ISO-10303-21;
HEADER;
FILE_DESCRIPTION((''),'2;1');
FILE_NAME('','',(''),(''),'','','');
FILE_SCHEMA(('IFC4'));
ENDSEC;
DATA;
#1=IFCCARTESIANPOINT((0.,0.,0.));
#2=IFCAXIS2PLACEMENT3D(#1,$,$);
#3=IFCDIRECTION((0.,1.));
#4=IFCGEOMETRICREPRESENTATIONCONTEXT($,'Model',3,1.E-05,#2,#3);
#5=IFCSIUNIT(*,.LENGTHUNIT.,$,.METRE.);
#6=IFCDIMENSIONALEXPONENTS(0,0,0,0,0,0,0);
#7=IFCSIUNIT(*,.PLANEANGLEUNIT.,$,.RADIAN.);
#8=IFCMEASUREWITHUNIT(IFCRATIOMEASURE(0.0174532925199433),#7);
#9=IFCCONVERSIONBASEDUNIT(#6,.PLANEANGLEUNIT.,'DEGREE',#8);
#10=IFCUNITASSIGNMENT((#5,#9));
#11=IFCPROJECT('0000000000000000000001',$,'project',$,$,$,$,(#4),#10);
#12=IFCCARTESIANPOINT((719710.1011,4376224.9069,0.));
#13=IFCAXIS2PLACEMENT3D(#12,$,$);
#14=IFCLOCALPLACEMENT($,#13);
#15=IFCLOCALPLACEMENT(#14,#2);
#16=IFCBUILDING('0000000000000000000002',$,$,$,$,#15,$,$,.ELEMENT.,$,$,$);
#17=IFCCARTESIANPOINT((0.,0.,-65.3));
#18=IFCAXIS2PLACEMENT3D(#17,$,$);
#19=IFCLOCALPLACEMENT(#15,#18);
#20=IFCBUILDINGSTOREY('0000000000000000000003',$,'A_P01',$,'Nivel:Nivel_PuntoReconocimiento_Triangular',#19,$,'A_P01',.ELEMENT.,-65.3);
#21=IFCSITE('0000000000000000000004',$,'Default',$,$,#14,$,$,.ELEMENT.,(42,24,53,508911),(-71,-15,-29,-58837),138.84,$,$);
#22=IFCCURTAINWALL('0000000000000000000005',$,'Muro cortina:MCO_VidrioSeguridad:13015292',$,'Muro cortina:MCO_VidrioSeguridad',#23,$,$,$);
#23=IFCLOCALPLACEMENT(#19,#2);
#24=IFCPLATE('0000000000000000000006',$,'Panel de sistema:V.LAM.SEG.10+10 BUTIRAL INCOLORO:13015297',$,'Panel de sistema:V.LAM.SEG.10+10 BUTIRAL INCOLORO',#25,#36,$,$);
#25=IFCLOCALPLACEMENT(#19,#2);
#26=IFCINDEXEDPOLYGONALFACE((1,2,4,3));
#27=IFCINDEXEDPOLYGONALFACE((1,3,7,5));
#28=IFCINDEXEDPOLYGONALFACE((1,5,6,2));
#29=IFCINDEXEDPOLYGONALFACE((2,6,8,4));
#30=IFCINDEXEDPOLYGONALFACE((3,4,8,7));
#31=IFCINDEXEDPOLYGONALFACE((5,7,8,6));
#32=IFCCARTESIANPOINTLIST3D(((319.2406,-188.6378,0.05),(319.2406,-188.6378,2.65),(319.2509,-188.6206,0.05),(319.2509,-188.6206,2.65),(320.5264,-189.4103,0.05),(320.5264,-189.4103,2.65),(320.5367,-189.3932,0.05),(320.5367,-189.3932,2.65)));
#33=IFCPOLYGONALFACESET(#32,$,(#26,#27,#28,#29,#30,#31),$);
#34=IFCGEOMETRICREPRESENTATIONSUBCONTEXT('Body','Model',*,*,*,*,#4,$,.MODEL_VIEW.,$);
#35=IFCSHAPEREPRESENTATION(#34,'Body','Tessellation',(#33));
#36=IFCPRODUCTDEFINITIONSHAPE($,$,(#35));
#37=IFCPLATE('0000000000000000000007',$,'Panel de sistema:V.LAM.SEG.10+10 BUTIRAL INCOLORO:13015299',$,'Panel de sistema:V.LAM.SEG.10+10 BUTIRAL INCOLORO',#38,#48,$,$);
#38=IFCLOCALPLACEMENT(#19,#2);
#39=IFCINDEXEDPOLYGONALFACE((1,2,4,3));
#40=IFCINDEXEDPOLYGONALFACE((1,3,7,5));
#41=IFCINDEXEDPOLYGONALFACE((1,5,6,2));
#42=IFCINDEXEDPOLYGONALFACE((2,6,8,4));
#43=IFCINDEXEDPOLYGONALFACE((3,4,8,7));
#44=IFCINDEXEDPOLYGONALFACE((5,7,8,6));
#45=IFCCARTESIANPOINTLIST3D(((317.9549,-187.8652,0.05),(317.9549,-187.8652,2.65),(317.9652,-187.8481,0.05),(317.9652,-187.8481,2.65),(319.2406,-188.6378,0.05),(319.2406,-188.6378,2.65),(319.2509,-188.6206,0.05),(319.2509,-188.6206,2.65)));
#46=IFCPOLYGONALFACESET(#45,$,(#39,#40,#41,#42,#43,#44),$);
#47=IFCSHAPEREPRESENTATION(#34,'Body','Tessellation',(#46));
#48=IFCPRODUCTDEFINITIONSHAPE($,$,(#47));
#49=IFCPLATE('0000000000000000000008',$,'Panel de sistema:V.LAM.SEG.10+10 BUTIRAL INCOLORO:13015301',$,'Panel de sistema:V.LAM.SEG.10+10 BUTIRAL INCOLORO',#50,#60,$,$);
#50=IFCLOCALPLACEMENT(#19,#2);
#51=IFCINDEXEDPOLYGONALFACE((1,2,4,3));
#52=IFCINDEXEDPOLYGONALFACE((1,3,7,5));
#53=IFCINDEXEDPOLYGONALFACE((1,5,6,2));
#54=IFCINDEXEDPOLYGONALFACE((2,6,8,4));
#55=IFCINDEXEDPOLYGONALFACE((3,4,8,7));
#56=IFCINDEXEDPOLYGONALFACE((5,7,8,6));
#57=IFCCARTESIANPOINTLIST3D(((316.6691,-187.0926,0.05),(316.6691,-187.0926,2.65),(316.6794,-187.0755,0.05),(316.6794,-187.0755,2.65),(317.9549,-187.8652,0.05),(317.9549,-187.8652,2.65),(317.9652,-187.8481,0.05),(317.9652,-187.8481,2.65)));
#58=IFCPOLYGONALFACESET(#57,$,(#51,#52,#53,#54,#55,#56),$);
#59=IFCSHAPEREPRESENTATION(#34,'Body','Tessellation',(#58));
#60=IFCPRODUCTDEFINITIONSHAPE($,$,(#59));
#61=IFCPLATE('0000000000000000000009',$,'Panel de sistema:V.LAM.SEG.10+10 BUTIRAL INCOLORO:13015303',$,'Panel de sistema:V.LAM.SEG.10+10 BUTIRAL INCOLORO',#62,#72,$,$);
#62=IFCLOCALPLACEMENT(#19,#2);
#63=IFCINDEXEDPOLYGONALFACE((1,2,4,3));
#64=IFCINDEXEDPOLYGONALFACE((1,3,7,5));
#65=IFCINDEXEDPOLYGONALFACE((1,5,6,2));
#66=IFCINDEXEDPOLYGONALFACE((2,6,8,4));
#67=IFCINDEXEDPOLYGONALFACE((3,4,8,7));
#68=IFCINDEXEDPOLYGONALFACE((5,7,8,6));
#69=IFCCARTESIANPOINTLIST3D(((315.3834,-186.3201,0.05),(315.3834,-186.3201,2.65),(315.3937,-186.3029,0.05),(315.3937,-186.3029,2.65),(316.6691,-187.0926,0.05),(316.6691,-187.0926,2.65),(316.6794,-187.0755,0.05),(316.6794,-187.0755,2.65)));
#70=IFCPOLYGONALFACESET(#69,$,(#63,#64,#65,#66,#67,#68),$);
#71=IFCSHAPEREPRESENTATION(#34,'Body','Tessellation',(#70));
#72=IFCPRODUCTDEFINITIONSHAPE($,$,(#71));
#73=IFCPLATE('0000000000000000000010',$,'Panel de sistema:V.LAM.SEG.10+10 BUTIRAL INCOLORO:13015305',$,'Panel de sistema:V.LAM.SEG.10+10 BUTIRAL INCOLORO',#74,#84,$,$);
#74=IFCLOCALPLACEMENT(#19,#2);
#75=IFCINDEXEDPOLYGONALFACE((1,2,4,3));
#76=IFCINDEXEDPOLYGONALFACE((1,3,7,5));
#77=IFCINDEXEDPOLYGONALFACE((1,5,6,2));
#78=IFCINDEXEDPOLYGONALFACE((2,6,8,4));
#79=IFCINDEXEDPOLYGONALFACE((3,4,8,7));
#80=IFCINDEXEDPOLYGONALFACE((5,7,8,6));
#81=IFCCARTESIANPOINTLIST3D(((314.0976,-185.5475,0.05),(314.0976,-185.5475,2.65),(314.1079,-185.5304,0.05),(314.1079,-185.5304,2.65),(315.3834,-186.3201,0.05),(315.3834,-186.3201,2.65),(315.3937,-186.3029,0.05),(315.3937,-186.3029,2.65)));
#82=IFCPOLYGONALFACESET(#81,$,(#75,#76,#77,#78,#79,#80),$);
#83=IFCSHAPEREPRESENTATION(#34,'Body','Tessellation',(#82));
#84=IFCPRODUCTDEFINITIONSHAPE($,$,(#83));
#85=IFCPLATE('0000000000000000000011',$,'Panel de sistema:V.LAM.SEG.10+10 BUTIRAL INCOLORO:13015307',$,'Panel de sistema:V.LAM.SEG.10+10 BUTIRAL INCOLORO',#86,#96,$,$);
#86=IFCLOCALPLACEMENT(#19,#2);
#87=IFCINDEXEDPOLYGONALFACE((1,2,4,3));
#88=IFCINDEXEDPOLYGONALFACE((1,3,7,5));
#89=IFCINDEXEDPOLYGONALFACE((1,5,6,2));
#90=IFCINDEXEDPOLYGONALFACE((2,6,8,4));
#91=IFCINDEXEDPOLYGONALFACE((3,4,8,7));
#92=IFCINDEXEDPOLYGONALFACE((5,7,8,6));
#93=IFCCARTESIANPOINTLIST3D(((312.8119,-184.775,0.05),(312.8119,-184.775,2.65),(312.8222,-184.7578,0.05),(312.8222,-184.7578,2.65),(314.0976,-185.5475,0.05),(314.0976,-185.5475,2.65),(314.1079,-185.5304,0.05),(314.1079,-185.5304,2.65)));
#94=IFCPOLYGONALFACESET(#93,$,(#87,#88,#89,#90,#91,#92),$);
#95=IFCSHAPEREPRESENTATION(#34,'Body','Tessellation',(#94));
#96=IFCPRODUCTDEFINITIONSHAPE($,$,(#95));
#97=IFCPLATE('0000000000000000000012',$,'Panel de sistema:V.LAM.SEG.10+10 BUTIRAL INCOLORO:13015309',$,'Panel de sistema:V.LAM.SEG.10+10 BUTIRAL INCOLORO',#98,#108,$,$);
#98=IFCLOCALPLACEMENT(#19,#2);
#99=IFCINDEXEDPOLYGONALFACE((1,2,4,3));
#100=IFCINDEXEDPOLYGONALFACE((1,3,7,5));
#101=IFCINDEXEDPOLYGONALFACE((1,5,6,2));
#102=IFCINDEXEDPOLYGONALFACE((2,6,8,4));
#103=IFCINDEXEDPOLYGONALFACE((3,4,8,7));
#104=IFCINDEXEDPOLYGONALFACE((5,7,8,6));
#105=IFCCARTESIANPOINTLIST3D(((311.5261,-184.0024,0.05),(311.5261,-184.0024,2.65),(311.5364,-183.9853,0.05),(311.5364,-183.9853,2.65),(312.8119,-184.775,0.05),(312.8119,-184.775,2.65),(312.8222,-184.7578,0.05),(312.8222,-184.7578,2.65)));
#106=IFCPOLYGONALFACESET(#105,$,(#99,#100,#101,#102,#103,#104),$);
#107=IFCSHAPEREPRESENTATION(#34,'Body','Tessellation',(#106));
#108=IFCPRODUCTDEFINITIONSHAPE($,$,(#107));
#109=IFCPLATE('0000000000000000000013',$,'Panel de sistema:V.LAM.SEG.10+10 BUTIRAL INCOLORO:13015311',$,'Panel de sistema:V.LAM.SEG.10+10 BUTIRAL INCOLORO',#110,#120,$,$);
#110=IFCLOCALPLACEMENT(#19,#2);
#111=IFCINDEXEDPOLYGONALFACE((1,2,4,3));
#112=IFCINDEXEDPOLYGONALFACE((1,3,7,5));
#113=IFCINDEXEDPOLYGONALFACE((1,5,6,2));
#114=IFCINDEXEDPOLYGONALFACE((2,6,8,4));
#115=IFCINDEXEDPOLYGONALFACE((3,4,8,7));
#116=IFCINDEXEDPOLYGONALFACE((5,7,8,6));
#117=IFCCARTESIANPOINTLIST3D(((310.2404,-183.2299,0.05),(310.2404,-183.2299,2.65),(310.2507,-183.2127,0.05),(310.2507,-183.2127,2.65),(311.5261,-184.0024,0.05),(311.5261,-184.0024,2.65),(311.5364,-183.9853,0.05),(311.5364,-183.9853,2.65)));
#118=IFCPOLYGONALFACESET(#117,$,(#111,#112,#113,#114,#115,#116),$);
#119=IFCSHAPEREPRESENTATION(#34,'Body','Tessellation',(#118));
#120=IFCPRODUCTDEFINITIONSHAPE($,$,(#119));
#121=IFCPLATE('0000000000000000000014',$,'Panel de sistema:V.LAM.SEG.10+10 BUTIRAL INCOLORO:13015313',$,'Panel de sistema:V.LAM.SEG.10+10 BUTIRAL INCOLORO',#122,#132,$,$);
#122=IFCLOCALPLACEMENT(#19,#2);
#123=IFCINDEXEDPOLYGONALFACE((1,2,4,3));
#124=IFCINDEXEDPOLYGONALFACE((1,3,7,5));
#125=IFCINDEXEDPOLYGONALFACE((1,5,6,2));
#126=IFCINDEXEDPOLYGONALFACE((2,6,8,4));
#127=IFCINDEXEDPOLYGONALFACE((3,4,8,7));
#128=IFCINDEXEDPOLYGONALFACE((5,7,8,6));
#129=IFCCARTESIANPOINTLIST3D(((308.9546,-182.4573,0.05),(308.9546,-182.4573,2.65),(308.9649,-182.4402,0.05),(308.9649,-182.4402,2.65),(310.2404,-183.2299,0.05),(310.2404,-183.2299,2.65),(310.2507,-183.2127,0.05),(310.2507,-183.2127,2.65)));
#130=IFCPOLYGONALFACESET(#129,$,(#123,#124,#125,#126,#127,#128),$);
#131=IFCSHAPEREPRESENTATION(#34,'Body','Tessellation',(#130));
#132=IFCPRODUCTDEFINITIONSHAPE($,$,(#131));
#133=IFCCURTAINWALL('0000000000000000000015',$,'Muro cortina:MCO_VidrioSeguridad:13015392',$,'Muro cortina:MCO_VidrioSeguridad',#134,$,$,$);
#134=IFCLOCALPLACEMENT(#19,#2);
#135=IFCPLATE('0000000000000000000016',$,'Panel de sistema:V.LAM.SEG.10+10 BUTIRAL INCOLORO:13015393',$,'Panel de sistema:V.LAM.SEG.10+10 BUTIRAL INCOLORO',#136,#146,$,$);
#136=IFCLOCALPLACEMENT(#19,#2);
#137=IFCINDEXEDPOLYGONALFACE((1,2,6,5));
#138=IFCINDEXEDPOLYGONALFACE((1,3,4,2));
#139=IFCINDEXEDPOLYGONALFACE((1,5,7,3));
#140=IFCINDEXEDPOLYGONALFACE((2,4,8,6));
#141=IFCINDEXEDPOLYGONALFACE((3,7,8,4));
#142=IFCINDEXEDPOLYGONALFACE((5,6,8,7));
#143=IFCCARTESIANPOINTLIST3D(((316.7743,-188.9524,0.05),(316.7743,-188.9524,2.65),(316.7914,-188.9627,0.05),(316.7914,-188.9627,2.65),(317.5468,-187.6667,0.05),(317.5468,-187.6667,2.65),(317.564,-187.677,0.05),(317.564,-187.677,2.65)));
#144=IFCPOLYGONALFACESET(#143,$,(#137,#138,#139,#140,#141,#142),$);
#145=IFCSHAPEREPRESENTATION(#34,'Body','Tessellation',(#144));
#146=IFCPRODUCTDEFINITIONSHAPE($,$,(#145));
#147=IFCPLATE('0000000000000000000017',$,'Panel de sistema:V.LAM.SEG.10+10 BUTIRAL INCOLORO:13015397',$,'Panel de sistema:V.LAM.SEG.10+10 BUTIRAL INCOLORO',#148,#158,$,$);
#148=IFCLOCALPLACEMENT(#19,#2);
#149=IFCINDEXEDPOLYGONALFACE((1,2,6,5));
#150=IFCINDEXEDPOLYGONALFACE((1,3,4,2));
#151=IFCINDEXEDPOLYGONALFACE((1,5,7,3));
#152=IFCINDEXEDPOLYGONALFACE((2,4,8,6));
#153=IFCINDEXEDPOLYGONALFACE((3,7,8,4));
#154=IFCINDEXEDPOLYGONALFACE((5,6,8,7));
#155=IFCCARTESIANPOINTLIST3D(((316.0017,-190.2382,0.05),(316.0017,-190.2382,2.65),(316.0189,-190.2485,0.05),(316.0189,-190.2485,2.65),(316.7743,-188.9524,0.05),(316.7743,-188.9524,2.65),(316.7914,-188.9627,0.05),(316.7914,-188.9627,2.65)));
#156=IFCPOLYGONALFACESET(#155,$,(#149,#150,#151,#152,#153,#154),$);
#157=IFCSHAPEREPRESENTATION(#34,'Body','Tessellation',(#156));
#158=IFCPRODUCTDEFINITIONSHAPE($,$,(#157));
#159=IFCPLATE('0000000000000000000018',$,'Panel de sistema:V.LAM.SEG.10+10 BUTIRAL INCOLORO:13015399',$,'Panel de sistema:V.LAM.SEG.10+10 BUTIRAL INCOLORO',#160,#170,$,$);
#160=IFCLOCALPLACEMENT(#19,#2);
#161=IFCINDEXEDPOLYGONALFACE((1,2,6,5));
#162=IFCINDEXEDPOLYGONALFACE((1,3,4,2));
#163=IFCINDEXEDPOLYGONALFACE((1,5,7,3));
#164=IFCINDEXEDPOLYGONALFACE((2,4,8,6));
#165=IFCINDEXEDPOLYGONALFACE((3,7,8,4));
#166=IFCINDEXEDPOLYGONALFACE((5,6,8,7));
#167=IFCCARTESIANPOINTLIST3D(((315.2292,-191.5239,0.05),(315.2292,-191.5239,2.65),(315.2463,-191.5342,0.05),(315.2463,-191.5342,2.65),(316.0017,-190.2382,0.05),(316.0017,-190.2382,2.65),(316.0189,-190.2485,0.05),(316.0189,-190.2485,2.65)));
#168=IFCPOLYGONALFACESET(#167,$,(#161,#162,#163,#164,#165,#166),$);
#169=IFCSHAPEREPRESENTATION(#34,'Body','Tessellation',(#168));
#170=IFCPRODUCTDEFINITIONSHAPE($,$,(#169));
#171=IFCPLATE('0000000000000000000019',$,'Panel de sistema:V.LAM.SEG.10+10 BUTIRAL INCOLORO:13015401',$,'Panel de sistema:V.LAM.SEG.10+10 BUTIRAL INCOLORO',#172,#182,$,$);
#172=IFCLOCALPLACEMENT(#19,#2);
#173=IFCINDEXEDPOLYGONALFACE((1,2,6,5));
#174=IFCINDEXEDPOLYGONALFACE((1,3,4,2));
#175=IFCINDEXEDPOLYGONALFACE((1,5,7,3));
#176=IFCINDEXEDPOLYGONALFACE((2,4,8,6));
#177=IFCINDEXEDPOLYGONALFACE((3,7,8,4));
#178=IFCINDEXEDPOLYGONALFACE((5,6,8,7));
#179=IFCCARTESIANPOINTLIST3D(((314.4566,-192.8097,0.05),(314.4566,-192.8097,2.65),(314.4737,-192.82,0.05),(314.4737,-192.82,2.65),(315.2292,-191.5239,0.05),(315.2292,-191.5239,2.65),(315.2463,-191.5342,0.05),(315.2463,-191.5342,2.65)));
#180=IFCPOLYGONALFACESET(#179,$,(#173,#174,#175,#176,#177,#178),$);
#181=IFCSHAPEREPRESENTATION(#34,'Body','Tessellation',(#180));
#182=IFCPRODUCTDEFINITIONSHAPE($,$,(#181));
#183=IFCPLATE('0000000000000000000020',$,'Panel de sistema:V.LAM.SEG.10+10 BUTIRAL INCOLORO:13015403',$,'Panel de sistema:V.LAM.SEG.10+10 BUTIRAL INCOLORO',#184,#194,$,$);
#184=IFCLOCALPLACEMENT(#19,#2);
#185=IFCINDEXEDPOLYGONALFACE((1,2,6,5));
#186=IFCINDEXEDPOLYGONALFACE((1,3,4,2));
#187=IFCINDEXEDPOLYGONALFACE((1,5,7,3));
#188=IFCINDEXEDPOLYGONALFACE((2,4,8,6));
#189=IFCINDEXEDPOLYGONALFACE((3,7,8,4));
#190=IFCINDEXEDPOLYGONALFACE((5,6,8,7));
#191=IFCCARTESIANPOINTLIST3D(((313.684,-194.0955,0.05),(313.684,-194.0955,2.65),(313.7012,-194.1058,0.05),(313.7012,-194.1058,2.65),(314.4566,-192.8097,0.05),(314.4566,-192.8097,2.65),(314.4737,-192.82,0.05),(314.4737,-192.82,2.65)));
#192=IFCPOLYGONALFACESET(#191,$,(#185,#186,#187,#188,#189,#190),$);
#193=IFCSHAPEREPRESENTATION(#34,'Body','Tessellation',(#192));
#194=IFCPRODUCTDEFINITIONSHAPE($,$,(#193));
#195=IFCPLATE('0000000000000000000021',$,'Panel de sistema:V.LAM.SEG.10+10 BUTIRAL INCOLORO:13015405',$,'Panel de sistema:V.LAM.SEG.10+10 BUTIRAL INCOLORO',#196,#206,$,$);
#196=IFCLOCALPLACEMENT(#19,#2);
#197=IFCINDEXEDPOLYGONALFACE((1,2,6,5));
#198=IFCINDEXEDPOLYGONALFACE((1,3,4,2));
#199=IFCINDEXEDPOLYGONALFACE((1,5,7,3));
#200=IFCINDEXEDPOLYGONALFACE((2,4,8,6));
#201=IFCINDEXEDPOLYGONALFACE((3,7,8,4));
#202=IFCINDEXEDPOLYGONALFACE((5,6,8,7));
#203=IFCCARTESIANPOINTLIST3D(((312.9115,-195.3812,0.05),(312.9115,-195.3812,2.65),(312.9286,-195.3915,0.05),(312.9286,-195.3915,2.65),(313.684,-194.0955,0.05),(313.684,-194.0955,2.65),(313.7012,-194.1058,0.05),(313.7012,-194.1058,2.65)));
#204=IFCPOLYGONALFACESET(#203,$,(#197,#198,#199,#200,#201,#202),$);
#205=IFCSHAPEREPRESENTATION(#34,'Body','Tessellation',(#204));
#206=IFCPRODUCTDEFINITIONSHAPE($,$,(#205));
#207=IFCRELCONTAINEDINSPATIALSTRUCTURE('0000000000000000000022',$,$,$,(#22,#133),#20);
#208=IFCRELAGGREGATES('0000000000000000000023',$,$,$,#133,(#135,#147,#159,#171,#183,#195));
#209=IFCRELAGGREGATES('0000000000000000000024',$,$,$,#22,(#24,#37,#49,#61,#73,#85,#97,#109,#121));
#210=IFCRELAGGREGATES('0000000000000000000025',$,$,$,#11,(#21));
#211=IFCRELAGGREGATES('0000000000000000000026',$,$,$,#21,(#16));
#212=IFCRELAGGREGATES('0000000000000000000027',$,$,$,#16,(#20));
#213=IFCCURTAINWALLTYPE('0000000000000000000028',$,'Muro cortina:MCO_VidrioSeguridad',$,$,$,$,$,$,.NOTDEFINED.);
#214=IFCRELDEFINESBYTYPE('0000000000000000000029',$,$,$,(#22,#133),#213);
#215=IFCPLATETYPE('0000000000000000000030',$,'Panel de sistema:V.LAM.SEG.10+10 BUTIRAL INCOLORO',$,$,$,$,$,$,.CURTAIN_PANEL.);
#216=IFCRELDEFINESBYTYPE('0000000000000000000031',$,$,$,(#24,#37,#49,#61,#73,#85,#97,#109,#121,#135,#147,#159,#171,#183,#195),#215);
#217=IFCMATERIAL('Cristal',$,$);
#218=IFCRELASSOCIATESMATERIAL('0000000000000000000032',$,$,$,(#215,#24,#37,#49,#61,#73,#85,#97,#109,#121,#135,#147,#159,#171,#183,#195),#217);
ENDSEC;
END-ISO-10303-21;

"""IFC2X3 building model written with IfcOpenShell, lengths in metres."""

from ifc_helpers import new_model, entity, si_unit, converted_unit, direction, frame, origin, origin_2d_with_axis, place, context, subcontext, project, spatial, rectangle, extrude, source, transform, mapped, material, type_object, type_shapes, element, aggregate, save


model = new_model("IFC2X3")

# Units and contexts
model_context = context("Model", 3, precision=1e-05, world=origin(), true_north=direction((0.0, 1.0)))
body_context = subcontext(model_context, "Body", "Model", "MODEL_VIEW")
ifc_project = project(units=[si_unit("LENGTHUNIT", "METRE"), converted_unit("PLANEANGLEUNIT", "DEGREE", entity("IfcRatioMeasure", 0.0174532925199433), si_unit("PLANEANGLEUNIT", "RADIAN"), dimensions=[0, 0, 0, 0, 0, 0, 0])], contexts=[model_context])

# Site, building, storey
site_placement = place(None, frame((719710.1011, 4376224.9069, 0.0)))
site = spatial("IfcSite", under=ifc_project, at=site_placement, Name="Default", CompositionType="ELEMENT", RefLatitude=(42, 24, 53, 508911), RefLongitude=(-71, -15, -29, -58837), RefElevation=138.84)
building_placement = place(site_placement, origin())
building = spatial("IfcBuilding", under=site, at=building_placement, CompositionType="ELEMENT")
storey_placement = place(building_placement, frame((0.0, 0.0, -65.3)))
storey = spatial("IfcBuildingStorey", under=building, at=storey_placement, Name="A_P01", ObjectType="Nivel:Nivel_PuntoReconocimiento_Triangular", LongName="A_P01", CompositionType="ELEMENT", Elevation=-65.3)

# Curtain walls, plates
curtain_wall_type = type_object("IfcCurtainWallType", Name="Muro cortina:MCO_VidrioSeguridad", PredefinedType="NOTDEFINED")
curtain_wall_1_placement = place(storey_placement, frame((0.0, 0.0, 65.3)))
curtain_wall_1 = element("IfcCurtainWall", 1, at=curtain_wall_1_placement, inside=storey, type_object=curtain_wall_type, Name="Muro cortina:MCO_VidrioSeguridad:13015292", ObjectType="Muro cortina:MCO_VidrioSeguridad")
ifc_material = material(Name="Cristal")
plate_type_1 = type_object("IfcPlateType", Name="Panel de sistema:V.LAM.SEG.10+10 BUTIRAL INCOLORO", PredefinedType="CURTAIN_PANEL", material=ifc_material)
shared_shape_1 = source(origin(), body_context, "Body", "SweptSolid", [
    extrude(rectangle(XDim=0.02, YDim=1.5, at=origin_2d_with_axis()), frame((0.0, 0.0, 0.0), z_axis=(0.0, 0.0, 1.0), x_axis=(0.0, 1.0, 0.0)), (0.0, 0.0, 1.0), 2.6),
])
type_shapes(plate_type_1, [shared_shape_1])
plate_1_placement = place(curtain_wall_1_placement, frame((319.8886, -189.0155, -65.25), z_axis=(0.0, 0.0, 1.0), x_axis=(-0.857167, 0.515038, 0.0)))
plate_1 = element("IfcPlate", 2, at=plate_1_placement, type_object=plate_type_1, material=ifc_material, Name="Panel de sistema:V.LAM.SEG.10+10 BUTIRAL INCOLORO:13015297", ObjectType="Panel de sistema:V.LAM.SEG.10+10 BUTIRAL INCOLORO", context=body_context, shape_type="MappedRepresentation", body=[
    mapped(shared_shape_1, transform((0.0, 0.0, 0.0), scale=1.0)),
])
plate_2_placement = place(curtain_wall_1_placement, frame((318.6029, -188.2429, -65.25), z_axis=(0.0, 0.0, 1.0), x_axis=(-0.857167, 0.515038, 0.0)))
plate_2 = element("IfcPlate", 3, at=plate_2_placement, type_object=plate_type_1, material=ifc_material, Name="Panel de sistema:V.LAM.SEG.10+10 BUTIRAL INCOLORO:13015299", ObjectType="Panel de sistema:V.LAM.SEG.10+10 BUTIRAL INCOLORO", context=body_context, shape_type="MappedRepresentation", body=[
    mapped(shared_shape_1, transform((0.0, 0.0, 0.0), scale=1.0)),
])
plate_3_placement = place(curtain_wall_1_placement, frame((317.3171, -187.4704, -65.25), z_axis=(0.0, 0.0, 1.0), x_axis=(-0.857167, 0.515038, 0.0)))
plate_3 = element("IfcPlate", 4, at=plate_3_placement, type_object=plate_type_1, material=ifc_material, Name="Panel de sistema:V.LAM.SEG.10+10 BUTIRAL INCOLORO:13015301", ObjectType="Panel de sistema:V.LAM.SEG.10+10 BUTIRAL INCOLORO", context=body_context, shape_type="MappedRepresentation", body=[
    mapped(shared_shape_1, transform((0.0, 0.0, 0.0), scale=1.0)),
])
plate_4_placement = place(curtain_wall_1_placement, frame((316.0314, -186.6978, -65.25), z_axis=(0.0, 0.0, 1.0), x_axis=(-0.857167, 0.515038, 0.0)))
plate_4 = element("IfcPlate", 5, at=plate_4_placement, type_object=plate_type_1, material=ifc_material, Name="Panel de sistema:V.LAM.SEG.10+10 BUTIRAL INCOLORO:13015303", ObjectType="Panel de sistema:V.LAM.SEG.10+10 BUTIRAL INCOLORO", context=body_context, shape_type="MappedRepresentation", body=[
    mapped(shared_shape_1, transform((0.0, 0.0, 0.0), scale=1.0)),
])
plate_5_placement = place(curtain_wall_1_placement, frame((314.7456, -185.9252, -65.25), z_axis=(0.0, 0.0, 1.0), x_axis=(-0.857167, 0.515038, 0.0)))
plate_5 = element("IfcPlate", 6, at=plate_5_placement, type_object=plate_type_1, material=ifc_material, Name="Panel de sistema:V.LAM.SEG.10+10 BUTIRAL INCOLORO:13015305", ObjectType="Panel de sistema:V.LAM.SEG.10+10 BUTIRAL INCOLORO", context=body_context, shape_type="MappedRepresentation", body=[
    mapped(shared_shape_1, transform((0.0, 0.0, 0.0), scale=1.0)),
])
plate_6_placement = place(curtain_wall_1_placement, frame((313.4599, -185.1527, -65.25), z_axis=(0.0, 0.0, 1.0), x_axis=(-0.857167, 0.515038, 0.0)))
plate_6 = element("IfcPlate", 7, at=plate_6_placement, type_object=plate_type_1, material=ifc_material, Name="Panel de sistema:V.LAM.SEG.10+10 BUTIRAL INCOLORO:13015307", ObjectType="Panel de sistema:V.LAM.SEG.10+10 BUTIRAL INCOLORO", context=body_context, shape_type="MappedRepresentation", body=[
    mapped(shared_shape_1, transform((0.0, 0.0, 0.0), scale=1.0)),
])
plate_7_placement = place(curtain_wall_1_placement, frame((312.1741, -184.3801, -65.25), z_axis=(0.0, 0.0, 1.0), x_axis=(-0.857167, 0.515038, 0.0)))
plate_7 = element("IfcPlate", 8, at=plate_7_placement, type_object=plate_type_1, material=ifc_material, Name="Panel de sistema:V.LAM.SEG.10+10 BUTIRAL INCOLORO:13015309", ObjectType="Panel de sistema:V.LAM.SEG.10+10 BUTIRAL INCOLORO", context=body_context, shape_type="MappedRepresentation", body=[
    mapped(shared_shape_1, transform((0.0, 0.0, 0.0), scale=1.0)),
])
plate_8_placement = place(curtain_wall_1_placement, frame((310.8884, -183.6076, -65.25), z_axis=(0.0, 0.0, 1.0), x_axis=(-0.857167, 0.515038, 0.0)))
plate_8 = element("IfcPlate", 9, at=plate_8_placement, type_object=plate_type_1, material=ifc_material, Name="Panel de sistema:V.LAM.SEG.10+10 BUTIRAL INCOLORO:13015311", ObjectType="Panel de sistema:V.LAM.SEG.10+10 BUTIRAL INCOLORO", context=body_context, shape_type="MappedRepresentation", body=[
    mapped(shared_shape_1, transform((0.0, 0.0, 0.0), scale=1.0)),
])
plate_9_placement = place(curtain_wall_1_placement, frame((309.6026, -182.835, -65.25), z_axis=(0.0, 0.0, 1.0), x_axis=(-0.857167, 0.515038, 0.0)))
plate_9 = element("IfcPlate", 10, at=plate_9_placement, type_object=plate_type_1, material=ifc_material, Name="Panel de sistema:V.LAM.SEG.10+10 BUTIRAL INCOLORO:13015313", ObjectType="Panel de sistema:V.LAM.SEG.10+10 BUTIRAL INCOLORO", context=body_context, shape_type="MappedRepresentation", body=[
    mapped(shared_shape_1, transform((0.0, 0.0, 0.0), scale=1.0)),
])
curtain_wall_2_placement = place(storey_placement, frame((0.0, 0.0, 65.3)))
curtain_wall_2 = element("IfcCurtainWall", 11, at=curtain_wall_2_placement, inside=storey, type_object=curtain_wall_type, Name="Muro cortina:MCO_VidrioSeguridad:13015392", ObjectType="Muro cortina:MCO_VidrioSeguridad")
plate_10_placement = place(curtain_wall_2_placement, frame((317.1691, -188.3147, -65.25), z_axis=(0.0, 0.0, 1.0), x_axis=(-0.515038, -0.857167, 0.0)))
plate_10 = element("IfcPlate", 12, at=plate_10_placement, type_object=plate_type_1, material=ifc_material, Name="Panel de sistema:V.LAM.SEG.10+10 BUTIRAL INCOLORO:13015393", ObjectType="Panel de sistema:V.LAM.SEG.10+10 BUTIRAL INCOLORO", context=body_context, shape_type="MappedRepresentation", body=[
    mapped(shared_shape_1, transform((0.0, 0.0, 0.0), scale=1.0)),
])
plate_11_placement = place(curtain_wall_2_placement, frame((316.3966, -189.6005, -65.25), z_axis=(0.0, 0.0, 1.0), x_axis=(-0.515038, -0.857167, 0.0)))
plate_11 = element("IfcPlate", 13, at=plate_11_placement, type_object=plate_type_1, material=ifc_material, Name="Panel de sistema:V.LAM.SEG.10+10 BUTIRAL INCOLORO:13015397", ObjectType="Panel de sistema:V.LAM.SEG.10+10 BUTIRAL INCOLORO", context=body_context, shape_type="MappedRepresentation", body=[
    mapped(shared_shape_1, transform((0.0, 0.0, 0.0), scale=1.0)),
])
plate_12_placement = place(curtain_wall_2_placement, frame((315.624, -190.8862, -65.25), z_axis=(0.0, 0.0, 1.0), x_axis=(-0.515038, -0.857167, 0.0)))
plate_12 = element("IfcPlate", 14, at=plate_12_placement, type_object=plate_type_1, material=ifc_material, Name="Panel de sistema:V.LAM.SEG.10+10 BUTIRAL INCOLORO:13015399", ObjectType="Panel de sistema:V.LAM.SEG.10+10 BUTIRAL INCOLORO", context=body_context, shape_type="MappedRepresentation", body=[
    mapped(shared_shape_1, transform((0.0, 0.0, 0.0), scale=1.0)),
])
plate_13_placement = place(curtain_wall_2_placement, frame((314.8514, -192.172, -65.25), z_axis=(0.0, 0.0, 1.0), x_axis=(-0.515038, -0.857167, 0.0)))
plate_13 = element("IfcPlate", 15, at=plate_13_placement, type_object=plate_type_1, material=ifc_material, Name="Panel de sistema:V.LAM.SEG.10+10 BUTIRAL INCOLORO:13015401", ObjectType="Panel de sistema:V.LAM.SEG.10+10 BUTIRAL INCOLORO", context=body_context, shape_type="MappedRepresentation", body=[
    mapped(shared_shape_1, transform((0.0, 0.0, 0.0), scale=1.0)),
])
plate_14_placement = place(curtain_wall_2_placement, frame((314.0789, -193.4577, -65.25), z_axis=(0.0, 0.0, 1.0), x_axis=(-0.515038, -0.857167, 0.0)))
plate_14 = element("IfcPlate", 16, at=plate_14_placement, type_object=plate_type_1, material=ifc_material, Name="Panel de sistema:V.LAM.SEG.10+10 BUTIRAL INCOLORO:13015403", ObjectType="Panel de sistema:V.LAM.SEG.10+10 BUTIRAL INCOLORO", context=body_context, shape_type="MappedRepresentation", body=[
    mapped(shared_shape_1, transform((0.0, 0.0, 0.0), scale=1.0)),
])
plate_15_placement = place(curtain_wall_2_placement, frame((313.3063, -194.7435, -65.25), z_axis=(0.0, 0.0, 1.0), x_axis=(-0.515038, -0.857167, 0.0)))
plate_15 = element("IfcPlate", 17, at=plate_15_placement, type_object=plate_type_1, material=ifc_material, Name="Panel de sistema:V.LAM.SEG.10+10 BUTIRAL INCOLORO:13015405", ObjectType="Panel de sistema:V.LAM.SEG.10+10 BUTIRAL INCOLORO", context=body_context, shape_type="MappedRepresentation", body=[
    mapped(shared_shape_1, transform((0.0, 0.0, 0.0), scale=1.0)),
])
aggregate(curtain_wall_2, [plate_10, plate_11, plate_12, plate_13, plate_14, plate_15])

aggregate(curtain_wall_1, [plate_1, plate_2, plate_3, plate_4, plate_5, plate_6, plate_7, plate_8, plate_9])

save(model, "model.ifc")
